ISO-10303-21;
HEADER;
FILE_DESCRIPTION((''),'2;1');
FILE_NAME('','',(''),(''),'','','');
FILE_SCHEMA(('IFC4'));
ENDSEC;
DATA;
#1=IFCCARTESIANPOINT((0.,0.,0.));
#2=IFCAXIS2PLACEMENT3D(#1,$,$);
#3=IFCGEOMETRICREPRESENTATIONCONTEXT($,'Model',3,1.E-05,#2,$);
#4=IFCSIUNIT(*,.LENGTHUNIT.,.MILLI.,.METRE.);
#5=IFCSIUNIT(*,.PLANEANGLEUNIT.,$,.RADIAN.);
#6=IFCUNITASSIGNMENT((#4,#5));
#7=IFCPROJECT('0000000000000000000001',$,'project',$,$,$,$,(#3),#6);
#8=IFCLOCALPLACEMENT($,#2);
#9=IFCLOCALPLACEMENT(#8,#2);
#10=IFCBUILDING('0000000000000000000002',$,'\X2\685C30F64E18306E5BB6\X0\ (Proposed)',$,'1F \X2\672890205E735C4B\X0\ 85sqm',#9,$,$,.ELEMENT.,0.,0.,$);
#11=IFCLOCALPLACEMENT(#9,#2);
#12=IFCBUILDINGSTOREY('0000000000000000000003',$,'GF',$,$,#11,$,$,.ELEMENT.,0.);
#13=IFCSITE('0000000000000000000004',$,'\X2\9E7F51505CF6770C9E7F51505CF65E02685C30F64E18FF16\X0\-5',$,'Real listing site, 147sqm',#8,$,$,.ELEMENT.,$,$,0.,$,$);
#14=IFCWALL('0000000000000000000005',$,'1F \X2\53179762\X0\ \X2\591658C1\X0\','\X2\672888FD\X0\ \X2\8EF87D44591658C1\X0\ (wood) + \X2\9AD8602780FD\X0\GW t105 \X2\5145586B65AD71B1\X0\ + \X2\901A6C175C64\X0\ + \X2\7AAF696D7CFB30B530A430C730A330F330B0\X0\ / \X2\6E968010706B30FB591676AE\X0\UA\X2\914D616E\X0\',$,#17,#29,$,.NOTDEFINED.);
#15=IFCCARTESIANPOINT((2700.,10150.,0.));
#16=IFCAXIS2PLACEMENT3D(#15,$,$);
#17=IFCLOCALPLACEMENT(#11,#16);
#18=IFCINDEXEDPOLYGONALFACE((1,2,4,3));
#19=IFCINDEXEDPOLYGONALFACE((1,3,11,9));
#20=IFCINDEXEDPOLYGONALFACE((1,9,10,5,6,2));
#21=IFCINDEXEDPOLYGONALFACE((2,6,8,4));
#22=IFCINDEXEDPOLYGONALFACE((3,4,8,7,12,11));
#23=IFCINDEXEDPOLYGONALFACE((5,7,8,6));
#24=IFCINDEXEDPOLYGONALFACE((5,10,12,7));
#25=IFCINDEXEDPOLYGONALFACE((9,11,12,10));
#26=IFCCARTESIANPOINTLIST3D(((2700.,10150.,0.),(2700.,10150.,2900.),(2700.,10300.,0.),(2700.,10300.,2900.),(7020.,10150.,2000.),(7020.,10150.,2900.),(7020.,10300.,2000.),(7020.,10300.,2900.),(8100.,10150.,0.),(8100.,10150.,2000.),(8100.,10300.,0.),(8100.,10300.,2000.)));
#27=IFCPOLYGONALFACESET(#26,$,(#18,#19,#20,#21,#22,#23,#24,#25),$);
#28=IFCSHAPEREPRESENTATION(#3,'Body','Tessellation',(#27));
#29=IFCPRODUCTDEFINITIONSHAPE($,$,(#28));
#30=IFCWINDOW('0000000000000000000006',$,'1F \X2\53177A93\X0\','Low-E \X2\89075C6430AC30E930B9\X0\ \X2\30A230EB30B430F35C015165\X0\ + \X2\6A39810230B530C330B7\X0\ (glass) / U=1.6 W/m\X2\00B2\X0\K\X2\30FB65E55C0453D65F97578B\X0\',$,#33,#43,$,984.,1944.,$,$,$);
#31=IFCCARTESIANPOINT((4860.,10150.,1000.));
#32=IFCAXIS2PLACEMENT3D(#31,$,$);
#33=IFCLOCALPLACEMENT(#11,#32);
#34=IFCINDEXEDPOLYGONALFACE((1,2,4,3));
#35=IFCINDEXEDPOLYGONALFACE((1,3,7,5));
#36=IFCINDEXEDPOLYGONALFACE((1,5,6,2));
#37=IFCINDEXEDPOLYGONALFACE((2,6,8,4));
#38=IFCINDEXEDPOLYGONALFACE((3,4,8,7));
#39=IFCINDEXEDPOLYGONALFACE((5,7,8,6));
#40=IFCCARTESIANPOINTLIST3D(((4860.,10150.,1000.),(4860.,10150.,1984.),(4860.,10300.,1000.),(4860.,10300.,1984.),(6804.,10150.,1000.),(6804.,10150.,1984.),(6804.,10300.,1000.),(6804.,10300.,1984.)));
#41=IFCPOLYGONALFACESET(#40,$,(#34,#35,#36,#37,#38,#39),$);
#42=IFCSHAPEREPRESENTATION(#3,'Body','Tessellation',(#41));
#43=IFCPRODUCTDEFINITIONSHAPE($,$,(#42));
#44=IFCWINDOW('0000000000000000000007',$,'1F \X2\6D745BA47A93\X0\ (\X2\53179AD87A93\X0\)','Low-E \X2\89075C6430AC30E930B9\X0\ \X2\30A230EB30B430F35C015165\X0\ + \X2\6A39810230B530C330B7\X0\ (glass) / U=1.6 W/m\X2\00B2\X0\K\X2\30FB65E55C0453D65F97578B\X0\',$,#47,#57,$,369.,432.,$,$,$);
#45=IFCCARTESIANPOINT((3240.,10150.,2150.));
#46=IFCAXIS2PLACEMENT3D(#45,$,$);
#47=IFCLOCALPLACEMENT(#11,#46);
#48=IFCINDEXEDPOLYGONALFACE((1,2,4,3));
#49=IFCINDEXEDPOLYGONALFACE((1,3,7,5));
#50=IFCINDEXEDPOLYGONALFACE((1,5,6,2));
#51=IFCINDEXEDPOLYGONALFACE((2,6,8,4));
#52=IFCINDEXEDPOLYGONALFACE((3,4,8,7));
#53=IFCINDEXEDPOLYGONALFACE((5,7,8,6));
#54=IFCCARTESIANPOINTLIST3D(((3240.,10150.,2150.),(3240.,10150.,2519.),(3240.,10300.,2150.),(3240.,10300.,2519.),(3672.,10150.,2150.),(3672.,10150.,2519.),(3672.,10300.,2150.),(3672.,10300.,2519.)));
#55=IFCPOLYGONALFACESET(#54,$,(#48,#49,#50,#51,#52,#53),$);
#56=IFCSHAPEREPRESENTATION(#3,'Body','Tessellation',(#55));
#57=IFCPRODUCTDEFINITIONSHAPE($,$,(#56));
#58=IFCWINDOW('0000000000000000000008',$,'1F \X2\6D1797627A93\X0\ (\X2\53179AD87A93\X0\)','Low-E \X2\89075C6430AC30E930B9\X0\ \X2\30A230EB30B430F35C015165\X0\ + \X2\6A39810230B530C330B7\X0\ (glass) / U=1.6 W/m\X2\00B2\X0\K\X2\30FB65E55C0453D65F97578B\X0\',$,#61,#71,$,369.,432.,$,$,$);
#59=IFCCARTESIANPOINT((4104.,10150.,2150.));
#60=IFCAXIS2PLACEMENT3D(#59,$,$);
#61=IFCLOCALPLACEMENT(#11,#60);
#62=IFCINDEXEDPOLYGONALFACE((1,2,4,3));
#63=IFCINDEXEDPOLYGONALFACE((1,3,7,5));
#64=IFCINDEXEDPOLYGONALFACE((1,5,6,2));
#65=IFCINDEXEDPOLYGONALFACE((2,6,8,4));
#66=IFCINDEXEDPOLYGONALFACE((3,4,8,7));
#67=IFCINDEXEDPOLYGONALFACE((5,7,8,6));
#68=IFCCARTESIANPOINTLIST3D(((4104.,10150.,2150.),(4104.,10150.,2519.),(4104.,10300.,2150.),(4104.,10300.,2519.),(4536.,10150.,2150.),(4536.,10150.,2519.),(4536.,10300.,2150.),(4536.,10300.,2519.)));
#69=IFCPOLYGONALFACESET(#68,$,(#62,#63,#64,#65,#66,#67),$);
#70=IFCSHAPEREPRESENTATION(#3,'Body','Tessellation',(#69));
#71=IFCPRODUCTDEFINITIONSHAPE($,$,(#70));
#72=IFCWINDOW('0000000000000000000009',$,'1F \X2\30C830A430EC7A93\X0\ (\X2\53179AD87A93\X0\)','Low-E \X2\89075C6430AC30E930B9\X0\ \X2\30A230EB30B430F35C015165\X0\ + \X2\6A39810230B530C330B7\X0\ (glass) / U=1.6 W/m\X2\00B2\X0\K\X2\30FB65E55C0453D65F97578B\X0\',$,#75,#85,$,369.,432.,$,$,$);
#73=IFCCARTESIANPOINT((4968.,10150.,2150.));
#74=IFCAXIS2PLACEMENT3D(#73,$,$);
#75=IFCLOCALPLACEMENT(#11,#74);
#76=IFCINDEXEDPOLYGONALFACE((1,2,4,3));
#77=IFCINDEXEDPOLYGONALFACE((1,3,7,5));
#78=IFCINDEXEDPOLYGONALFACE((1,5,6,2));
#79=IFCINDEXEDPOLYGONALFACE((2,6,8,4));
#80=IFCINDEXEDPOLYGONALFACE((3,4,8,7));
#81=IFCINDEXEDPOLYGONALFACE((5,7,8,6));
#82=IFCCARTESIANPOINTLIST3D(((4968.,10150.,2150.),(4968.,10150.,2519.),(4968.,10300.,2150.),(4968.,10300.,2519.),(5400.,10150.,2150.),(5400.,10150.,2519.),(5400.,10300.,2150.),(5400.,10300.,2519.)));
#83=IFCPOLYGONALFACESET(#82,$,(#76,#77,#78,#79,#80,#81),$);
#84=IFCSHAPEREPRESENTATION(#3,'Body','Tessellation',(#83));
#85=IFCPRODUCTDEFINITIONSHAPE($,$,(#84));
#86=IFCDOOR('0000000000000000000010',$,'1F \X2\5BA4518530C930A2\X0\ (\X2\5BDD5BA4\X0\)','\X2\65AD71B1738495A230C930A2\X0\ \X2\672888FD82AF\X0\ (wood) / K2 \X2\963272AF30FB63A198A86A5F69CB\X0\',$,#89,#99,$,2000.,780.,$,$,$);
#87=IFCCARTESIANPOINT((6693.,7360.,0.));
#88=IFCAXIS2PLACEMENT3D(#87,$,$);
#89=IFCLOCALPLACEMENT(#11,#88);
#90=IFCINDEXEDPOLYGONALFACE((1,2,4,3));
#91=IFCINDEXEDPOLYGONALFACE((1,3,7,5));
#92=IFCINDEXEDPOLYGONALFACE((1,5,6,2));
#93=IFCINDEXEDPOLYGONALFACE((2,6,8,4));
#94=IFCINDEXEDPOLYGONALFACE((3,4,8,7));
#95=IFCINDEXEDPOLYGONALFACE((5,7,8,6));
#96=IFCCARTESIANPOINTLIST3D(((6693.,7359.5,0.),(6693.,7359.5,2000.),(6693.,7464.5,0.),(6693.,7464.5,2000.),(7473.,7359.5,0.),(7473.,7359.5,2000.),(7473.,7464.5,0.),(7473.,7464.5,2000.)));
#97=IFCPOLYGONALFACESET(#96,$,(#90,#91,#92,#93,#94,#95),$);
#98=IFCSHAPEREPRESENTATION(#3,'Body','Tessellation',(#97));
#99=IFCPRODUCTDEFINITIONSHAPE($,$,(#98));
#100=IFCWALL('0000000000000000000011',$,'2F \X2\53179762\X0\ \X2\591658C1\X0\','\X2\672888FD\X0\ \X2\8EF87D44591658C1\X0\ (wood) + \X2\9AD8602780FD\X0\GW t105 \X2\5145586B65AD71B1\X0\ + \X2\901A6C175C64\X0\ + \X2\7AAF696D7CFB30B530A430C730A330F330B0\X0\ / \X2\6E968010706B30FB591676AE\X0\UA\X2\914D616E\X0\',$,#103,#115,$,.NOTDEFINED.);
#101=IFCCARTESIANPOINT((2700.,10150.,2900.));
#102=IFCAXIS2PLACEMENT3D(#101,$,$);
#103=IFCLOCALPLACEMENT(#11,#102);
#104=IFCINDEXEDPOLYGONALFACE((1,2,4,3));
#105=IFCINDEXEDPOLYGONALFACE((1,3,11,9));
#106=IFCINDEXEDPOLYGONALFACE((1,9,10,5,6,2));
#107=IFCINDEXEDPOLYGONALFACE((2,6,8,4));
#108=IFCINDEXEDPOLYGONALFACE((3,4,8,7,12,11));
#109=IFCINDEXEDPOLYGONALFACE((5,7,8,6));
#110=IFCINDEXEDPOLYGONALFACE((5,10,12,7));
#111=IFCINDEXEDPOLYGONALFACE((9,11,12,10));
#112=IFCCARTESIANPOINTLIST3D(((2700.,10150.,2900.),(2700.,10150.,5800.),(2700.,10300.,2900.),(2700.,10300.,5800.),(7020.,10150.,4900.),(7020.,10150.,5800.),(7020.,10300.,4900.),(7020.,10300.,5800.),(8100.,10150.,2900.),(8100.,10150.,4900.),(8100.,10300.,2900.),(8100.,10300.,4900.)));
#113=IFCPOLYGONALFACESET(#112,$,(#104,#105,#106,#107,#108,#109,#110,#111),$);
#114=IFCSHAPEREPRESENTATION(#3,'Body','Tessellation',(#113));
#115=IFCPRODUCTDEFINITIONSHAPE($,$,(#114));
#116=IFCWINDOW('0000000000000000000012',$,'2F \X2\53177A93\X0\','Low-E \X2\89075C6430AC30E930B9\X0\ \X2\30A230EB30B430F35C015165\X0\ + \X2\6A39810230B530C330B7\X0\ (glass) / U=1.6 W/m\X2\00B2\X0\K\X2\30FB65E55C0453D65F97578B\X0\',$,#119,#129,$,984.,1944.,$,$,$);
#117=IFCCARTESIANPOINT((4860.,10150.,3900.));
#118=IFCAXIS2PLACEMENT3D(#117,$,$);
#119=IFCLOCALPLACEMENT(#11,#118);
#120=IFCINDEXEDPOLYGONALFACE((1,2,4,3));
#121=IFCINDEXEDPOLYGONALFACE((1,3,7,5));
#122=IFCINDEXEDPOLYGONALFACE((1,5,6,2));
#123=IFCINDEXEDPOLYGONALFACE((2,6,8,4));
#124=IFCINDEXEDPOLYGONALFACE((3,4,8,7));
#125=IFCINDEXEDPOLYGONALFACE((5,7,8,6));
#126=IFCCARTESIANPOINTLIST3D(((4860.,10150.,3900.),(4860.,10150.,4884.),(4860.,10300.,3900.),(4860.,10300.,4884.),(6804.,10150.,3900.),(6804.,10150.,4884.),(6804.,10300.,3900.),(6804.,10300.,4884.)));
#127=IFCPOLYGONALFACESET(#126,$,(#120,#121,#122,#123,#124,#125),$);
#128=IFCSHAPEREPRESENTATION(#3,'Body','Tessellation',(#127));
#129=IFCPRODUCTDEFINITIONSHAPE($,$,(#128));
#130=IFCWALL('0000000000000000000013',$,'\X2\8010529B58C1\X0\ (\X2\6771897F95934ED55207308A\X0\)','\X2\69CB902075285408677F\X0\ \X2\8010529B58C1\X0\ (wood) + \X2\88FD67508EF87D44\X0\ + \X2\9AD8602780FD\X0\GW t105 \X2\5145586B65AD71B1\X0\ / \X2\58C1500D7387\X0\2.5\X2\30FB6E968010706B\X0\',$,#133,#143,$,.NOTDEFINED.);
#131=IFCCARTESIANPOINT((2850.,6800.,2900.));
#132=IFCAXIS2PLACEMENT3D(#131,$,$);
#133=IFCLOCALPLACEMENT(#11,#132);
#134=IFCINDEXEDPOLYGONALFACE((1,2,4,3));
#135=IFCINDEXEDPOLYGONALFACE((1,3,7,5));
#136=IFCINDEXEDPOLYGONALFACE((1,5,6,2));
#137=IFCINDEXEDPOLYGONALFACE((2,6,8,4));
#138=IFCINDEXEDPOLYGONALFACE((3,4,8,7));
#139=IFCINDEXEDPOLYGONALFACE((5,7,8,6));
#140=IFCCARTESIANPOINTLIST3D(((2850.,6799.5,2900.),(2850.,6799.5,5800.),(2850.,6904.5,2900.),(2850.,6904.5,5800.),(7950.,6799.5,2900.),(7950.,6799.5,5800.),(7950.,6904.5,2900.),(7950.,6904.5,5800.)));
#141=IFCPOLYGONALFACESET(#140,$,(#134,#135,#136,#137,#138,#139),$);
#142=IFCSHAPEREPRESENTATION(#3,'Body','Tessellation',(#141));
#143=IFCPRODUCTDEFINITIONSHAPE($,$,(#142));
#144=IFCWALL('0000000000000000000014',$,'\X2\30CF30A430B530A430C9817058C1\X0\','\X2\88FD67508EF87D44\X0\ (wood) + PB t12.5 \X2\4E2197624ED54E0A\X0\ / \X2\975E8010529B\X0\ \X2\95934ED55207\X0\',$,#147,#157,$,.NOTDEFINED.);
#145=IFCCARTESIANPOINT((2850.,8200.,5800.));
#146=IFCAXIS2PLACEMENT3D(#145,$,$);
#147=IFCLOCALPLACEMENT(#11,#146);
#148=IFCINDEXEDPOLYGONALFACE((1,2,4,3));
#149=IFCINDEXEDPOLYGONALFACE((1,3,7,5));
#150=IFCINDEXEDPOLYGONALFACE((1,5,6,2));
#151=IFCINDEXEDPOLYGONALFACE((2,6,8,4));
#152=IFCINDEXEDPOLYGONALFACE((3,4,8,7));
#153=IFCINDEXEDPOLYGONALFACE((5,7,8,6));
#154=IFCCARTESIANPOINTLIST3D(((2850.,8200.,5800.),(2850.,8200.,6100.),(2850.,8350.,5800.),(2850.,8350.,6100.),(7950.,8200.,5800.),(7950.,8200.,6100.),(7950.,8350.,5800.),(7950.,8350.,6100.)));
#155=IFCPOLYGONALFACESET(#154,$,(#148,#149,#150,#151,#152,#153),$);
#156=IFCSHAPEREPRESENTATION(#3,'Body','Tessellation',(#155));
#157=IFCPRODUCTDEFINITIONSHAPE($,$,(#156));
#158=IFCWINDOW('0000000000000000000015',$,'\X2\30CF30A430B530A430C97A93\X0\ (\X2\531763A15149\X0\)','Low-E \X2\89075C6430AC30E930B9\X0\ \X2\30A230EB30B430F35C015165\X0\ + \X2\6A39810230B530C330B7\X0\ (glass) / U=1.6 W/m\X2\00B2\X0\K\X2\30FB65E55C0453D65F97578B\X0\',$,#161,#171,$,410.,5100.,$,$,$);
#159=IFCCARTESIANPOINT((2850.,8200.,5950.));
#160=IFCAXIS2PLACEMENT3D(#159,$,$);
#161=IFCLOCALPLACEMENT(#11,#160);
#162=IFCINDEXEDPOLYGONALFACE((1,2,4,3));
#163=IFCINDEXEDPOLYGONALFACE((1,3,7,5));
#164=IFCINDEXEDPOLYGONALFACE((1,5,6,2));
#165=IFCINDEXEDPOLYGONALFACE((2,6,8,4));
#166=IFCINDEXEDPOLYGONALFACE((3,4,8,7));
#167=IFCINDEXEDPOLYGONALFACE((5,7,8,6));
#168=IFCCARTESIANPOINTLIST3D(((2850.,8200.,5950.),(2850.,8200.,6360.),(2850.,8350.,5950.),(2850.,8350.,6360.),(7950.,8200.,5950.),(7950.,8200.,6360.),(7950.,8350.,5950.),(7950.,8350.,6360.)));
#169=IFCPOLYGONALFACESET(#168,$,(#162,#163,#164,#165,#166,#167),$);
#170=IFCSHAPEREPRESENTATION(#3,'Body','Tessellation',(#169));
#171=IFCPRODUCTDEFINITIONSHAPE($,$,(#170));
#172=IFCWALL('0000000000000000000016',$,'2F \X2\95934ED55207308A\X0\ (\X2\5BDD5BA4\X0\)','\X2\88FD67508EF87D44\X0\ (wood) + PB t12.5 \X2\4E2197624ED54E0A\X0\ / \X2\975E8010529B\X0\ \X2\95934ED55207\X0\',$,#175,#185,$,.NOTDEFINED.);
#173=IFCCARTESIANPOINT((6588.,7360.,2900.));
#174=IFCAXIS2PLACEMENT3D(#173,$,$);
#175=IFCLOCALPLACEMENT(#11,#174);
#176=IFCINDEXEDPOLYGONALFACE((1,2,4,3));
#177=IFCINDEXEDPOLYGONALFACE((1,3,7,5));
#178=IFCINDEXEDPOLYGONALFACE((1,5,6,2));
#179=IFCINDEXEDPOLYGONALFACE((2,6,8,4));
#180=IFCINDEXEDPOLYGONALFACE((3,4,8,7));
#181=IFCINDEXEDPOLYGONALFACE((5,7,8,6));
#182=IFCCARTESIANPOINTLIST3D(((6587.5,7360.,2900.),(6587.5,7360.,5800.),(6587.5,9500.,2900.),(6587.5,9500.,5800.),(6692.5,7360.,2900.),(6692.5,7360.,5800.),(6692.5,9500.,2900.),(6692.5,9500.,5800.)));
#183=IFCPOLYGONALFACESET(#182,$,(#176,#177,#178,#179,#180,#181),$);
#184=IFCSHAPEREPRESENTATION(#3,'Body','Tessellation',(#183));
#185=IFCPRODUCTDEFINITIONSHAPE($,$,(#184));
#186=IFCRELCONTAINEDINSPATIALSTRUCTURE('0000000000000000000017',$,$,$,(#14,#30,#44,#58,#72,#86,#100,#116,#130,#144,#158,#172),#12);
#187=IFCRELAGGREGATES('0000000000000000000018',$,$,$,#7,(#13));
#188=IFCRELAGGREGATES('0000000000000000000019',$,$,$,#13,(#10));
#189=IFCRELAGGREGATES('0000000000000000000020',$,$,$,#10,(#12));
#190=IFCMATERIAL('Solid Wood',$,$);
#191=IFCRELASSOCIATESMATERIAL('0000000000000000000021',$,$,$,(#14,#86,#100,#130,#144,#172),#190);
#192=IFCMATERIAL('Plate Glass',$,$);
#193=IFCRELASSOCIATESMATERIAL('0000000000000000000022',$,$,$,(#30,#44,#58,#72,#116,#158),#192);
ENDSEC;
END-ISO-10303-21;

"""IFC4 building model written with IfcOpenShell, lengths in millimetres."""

from ifc_helpers import new_model, si_unit, frame, frame_2d, origin, place, context, project, spatial, rectangle, extrude, material, element, fill, save


model = new_model("IFC4")

# Units and contexts
model_context = context("Model", 3, precision=1e-05, world=origin())
ifc_project = project(units=[si_unit("LENGTHUNIT", "METRE", prefix="MILLI"), si_unit("PLANEANGLEUNIT", "RADIAN")], contexts=[model_context])

# Site, building, storey
site_placement = place(None, origin())
site = spatial("IfcSite", under=ifc_project, at=site_placement, Name="鹿児島県鹿児島市桜ヶ丘６-5", ObjectType="Real listing site, 147sqm", CompositionType="ELEMENT", RefElevation=0.0)
building_placement = place(site_placement, origin())
building = spatial("IfcBuilding", under=site, at=building_placement, Name="桜ヶ丘の家 (Proposed)", ObjectType="1F 木造平屋 85sqm", CompositionType="ELEMENT", ElevationOfRefHeight=0.0, ElevationOfTerrain=0.0)
storey_placement = place(building_placement, origin())
storey = spatial("IfcBuildingStorey", under=building, at=storey_placement, Name="GF", CompositionType="ELEMENT", Elevation=0.0)

# Wall, openings, windows
ifc_material_1 = material(Name="Solid Wood")
wall_1_placement = place(storey_placement, frame((2700.0, 10150.0, 0.0)))
wall_1 = element("IfcWall", 1, at=wall_1_placement, inside=storey, material=ifc_material_1, Name="1F 北面 外壁", Description="木製 軸組外壁 (wood) + 高性能GW t105 充填断熱 + 通気層 + 窯業系サイディング / 準耐火・外皮UA配慮", PredefinedType="NOTDEFINED", context=model_context, shape_type="SweptSolid", body=[
    extrude(rectangle(XDim=5400.0, YDim=150.0, at=frame_2d((2700.0, 75.0))), frame((2700.0, 10150.0, 0.0)), (0.0, 0.0, 1.0), 2900.0),
])
opening_1_placement = place(storey_placement, frame((4860.0, 10150.0, 1000.0)))
opening_1 = element("IfcOpeningElement", 2, at=opening_1_placement, cuts=wall_1, PredefinedType="NOTDEFINED", context=model_context, shape_type="SweptSolid", body=[
    extrude(rectangle(XDim=1944.0, YDim=150.0, at=frame_2d((972.0, 75.0))), frame((4860.0, 10150.0, 1000.0)), (0.0, 0.0, 1.0), 984.0),
])
opening_2_placement = place(storey_placement, frame((3240.0, 10150.0, 2150.0)))
opening_2 = element("IfcOpeningElement", 3, at=opening_2_placement, cuts=wall_1, PredefinedType="NOTDEFINED", context=model_context, shape_type="SweptSolid", body=[
    extrude(rectangle(XDim=432.0, YDim=150.0, at=frame_2d((216.0, 75.0))), frame((3240.0, 10150.0, 2150.0)), (0.0, 0.0, 1.0), 369.0),
])
opening_3_placement = place(storey_placement, frame((4104.0, 10150.0, 2150.0)))
opening_3 = element("IfcOpeningElement", 4, at=opening_3_placement, cuts=wall_1, PredefinedType="NOTDEFINED", context=model_context, shape_type="SweptSolid", body=[
    extrude(rectangle(XDim=432.0, YDim=150.0, at=frame_2d((216.0, 75.0))), frame((4104.0, 10150.0, 2150.0)), (0.0, 0.0, 1.0), 369.0),
])
opening_4_placement = place(storey_placement, frame((4968.0, 10150.0, 2150.0)))
opening_4 = element("IfcOpeningElement", 5, at=opening_4_placement, cuts=wall_1, PredefinedType="NOTDEFINED", context=model_context, shape_type="SweptSolid", body=[
    extrude(rectangle(XDim=432.0, YDim=150.0, at=frame_2d((216.0, 75.0))), frame((4968.0, 10150.0, 2150.0)), (0.0, 0.0, 1.0), 369.0),
])
ifc_material_2 = material(Name="Plate Glass")
window_1_placement = place(storey_placement, frame((4860.0, 10150.0, 1000.0)))
window_1 = element("IfcWindow", 6, at=window_1_placement, inside=storey, material=ifc_material_2, Name="1F 北窓", Description="Low-E 複層ガラス アルゴン封入 + 樹脂サッシ (glass) / U=1.6 W/m²K・日射取得型", OverallHeight=984.0, OverallWidth=1944.0, context=model_context, shape_type="SweptSolid", body=[
    extrude(rectangle(XDim=1944.0, YDim=150.0, at=frame_2d((972.0, 75.0))), frame((4860.0, 10150.0, 1000.0)), (0.0, 0.0, 1.0), 984.0),
])
fill(opening_1, window_1)
window_2_placement = place(storey_placement, frame((3240.0, 10150.0, 2150.0)))
window_2 = element("IfcWindow", 7, at=window_2_placement, inside=storey, material=ifc_material_2, Name="1F 浴室窓 (北高窓)", Description="Low-E 複層ガラス アルゴン封入 + 樹脂サッシ (glass) / U=1.6 W/m²K・日射取得型", OverallHeight=369.0, OverallWidth=432.0, context=model_context, shape_type="SweptSolid", body=[
    extrude(rectangle(XDim=432.0, YDim=150.0, at=frame_2d((216.0, 75.0))), frame((3240.0, 10150.0, 2150.0)), (0.0, 0.0, 1.0), 369.0),
])
fill(opening_2, window_2)
window_3_placement = place(storey_placement, frame((4104.0, 10150.0, 2150.0)))
window_3 = element("IfcWindow", 8, at=window_3_placement, inside=storey, material=ifc_material_2, Name="1F 洗面窓 (北高窓)", Description="Low-E 複層ガラス アルゴン封入 + 樹脂サッシ (glass) / U=1.6 W/m²K・日射取得型", OverallHeight=369.0, OverallWidth=432.0, context=model_context, shape_type="SweptSolid", body=[
    extrude(rectangle(XDim=432.0, YDim=150.0, at=frame_2d((216.0, 75.0))), frame((4104.0, 10150.0, 2150.0)), (0.0, 0.0, 1.0), 369.0),
])
fill(opening_3, window_3)
window_4_placement = place(storey_placement, frame((4968.0, 10150.0, 2150.0)))
window_4 = element("IfcWindow", 9, at=window_4_placement, inside=storey, material=ifc_material_2, Name="1F トイレ窓 (北高窓)", Description="Low-E 複層ガラス アルゴン封入 + 樹脂サッシ (glass) / U=1.6 W/m²K・日射取得型", OverallHeight=369.0, OverallWidth=432.0, context=model_context, shape_type="SweptSolid", body=[
    extrude(rectangle(XDim=432.0, YDim=150.0, at=frame_2d((216.0, 75.0))), frame((4968.0, 10150.0, 2150.0)), (0.0, 0.0, 1.0), 369.0),
])
fill(opening_4, window_4)

# Door
door_1_placement = place(storey_placement, frame((6693.0, 7360.0, 0.0)))
element("IfcDoor", 10, at=door_1_placement, inside=storey, material=ifc_material_1, Name="1F 室内ドア (寝室)", Description="断熱玄関ドア 木製芯 (wood) / K2 防犯・採風機構", OverallHeight=2000.0, OverallWidth=780.0, context=model_context, shape_type="SweptSolid", body=[
    extrude(rectangle(XDim=780.0, YDim=105.0, at=frame_2d((390.0, 52.0))), frame((6693.0, 7360.0, 0.0)), (0.0, 0.0, 1.0), 2000.0),
])

# Wall, opening, window
wall_2_placement = place(storey_placement, frame((2700.0, 10150.0, 2900.0)))
wall_2 = element("IfcWall", 11, at=wall_2_placement, inside=storey, material=ifc_material_1, Name="2F 北面 外壁", Description="木製 軸組外壁 (wood) + 高性能GW t105 充填断熱 + 通気層 + 窯業系サイディング / 準耐火・外皮UA配慮", PredefinedType="NOTDEFINED", context=model_context, shape_type="SweptSolid", body=[
    extrude(rectangle(XDim=5400.0, YDim=150.0, at=frame_2d((2700.0, 75.0))), frame((2700.0, 10150.0, 2900.0)), (0.0, 0.0, 1.0), 2900.0),
])
opening_5_placement = place(storey_placement, frame((4860.0, 10150.0, 3900.0)))
opening_5 = element("IfcOpeningElement", 12, at=opening_5_placement, cuts=wall_2, PredefinedType="NOTDEFINED", context=model_context, shape_type="SweptSolid", body=[
    extrude(rectangle(XDim=1944.0, YDim=150.0, at=frame_2d((972.0, 75.0))), frame((4860.0, 10150.0, 3900.0)), (0.0, 0.0, 1.0), 984.0),
])
window_5_placement = place(storey_placement, frame((4860.0, 10150.0, 3900.0)))
window_5 = element("IfcWindow", 13, at=window_5_placement, inside=storey, material=ifc_material_2, Name="2F 北窓", Description="Low-E 複層ガラス アルゴン封入 + 樹脂サッシ (glass) / U=1.6 W/m²K・日射取得型", OverallHeight=984.0, OverallWidth=1944.0, context=model_context, shape_type="SweptSolid", body=[
    extrude(rectangle(XDim=1944.0, YDim=150.0, at=frame_2d((972.0, 75.0))), frame((4860.0, 10150.0, 3900.0)), (0.0, 0.0, 1.0), 984.0),
])
fill(opening_5, window_5)

# Wall
wall_3_placement = place(storey_placement, frame((2850.0, 6800.0, 2900.0)))
element("IfcWall", 14, at=wall_3_placement, inside=storey, material=ifc_material_1, Name="耐力壁 (東西間仕切り)", Description="構造用合板 耐力壁 (wood) + 製材軸組 + 高性能GW t105 充填断熱 / 壁倍率2.5・準耐火", PredefinedType="NOTDEFINED", context=model_context, shape_type="SweptSolid", body=[
    extrude(rectangle(XDim=5100.0, YDim=105.0, at=frame_2d((2550.0, 52.0))), frame((2850.0, 6800.0, 2900.0)), (0.0, 0.0, 1.0), 2900.0),
])

# Wall, opening, window
wall_4_placement = place(storey_placement, frame((2850.0, 8200.0, 5800.0)))
wall_4 = element("IfcWall", 15, at=wall_4_placement, inside=storey, material=ifc_material_1, Name="ハイサイド腰壁", Description="製材軸組 (wood) + PB t12.5 両面仕上 / 非耐力 間仕切", PredefinedType="NOTDEFINED", context=model_context, shape_type="SweptSolid", body=[
    extrude(rectangle(XDim=5100.0, YDim=150.0, at=frame_2d((2550.0, 75.0))), frame((2850.0, 8200.0, 5800.0)), (0.0, 0.0, 1.0), 700.0),
])
opening_6_placement = place(storey_placement, frame((2850.0, 8200.0, 5950.0)))
opening_6 = element("IfcOpeningElement", 16, at=opening_6_placement, cuts=wall_4, PredefinedType="NOTDEFINED", context=model_context, shape_type="SweptSolid", body=[
    extrude(rectangle(XDim=5100.0, YDim=150.0, at=frame_2d((2550.0, 75.0))), frame((2850.0, 8200.0, 5950.0)), (0.0, 0.0, 1.0), 410.0),
])
window_6_placement = place(storey_placement, frame((2850.0, 8200.0, 5950.0)))
window_6 = element("IfcWindow", 17, at=window_6_placement, inside=storey, material=ifc_material_2, Name="ハイサイド窓 (北採光)", Description="Low-E 複層ガラス アルゴン封入 + 樹脂サッシ (glass) / U=1.6 W/m²K・日射取得型", OverallHeight=410.0, OverallWidth=5100.0, context=model_context, shape_type="SweptSolid", body=[
    extrude(rectangle(XDim=5100.0, YDim=150.0, at=frame_2d((2550.0, 75.0))), frame((2850.0, 8200.0, 5950.0)), (0.0, 0.0, 1.0), 410.0),
])
fill(opening_6, window_6)

# Wall
wall_5_placement = place(storey_placement, frame((6588.0, 7360.0, 2900.0)))
element("IfcWall", 18, at=wall_5_placement, inside=storey, material=ifc_material_1, Name="2F 間仕切り (寝室)", Description="製材軸組 (wood) + PB t12.5 両面仕上 / 非耐力 間仕切", PredefinedType="NOTDEFINED", context=model_context, shape_type="SweptSolid", body=[
    extrude(rectangle(XDim=105.0, YDim=2140.0, at=frame_2d((52.0, 1070.0))), frame((6588.0, 7360.0, 2900.0)), (0.0, 0.0, 1.0), 2900.0),
])

save(model, "model.ifc")
